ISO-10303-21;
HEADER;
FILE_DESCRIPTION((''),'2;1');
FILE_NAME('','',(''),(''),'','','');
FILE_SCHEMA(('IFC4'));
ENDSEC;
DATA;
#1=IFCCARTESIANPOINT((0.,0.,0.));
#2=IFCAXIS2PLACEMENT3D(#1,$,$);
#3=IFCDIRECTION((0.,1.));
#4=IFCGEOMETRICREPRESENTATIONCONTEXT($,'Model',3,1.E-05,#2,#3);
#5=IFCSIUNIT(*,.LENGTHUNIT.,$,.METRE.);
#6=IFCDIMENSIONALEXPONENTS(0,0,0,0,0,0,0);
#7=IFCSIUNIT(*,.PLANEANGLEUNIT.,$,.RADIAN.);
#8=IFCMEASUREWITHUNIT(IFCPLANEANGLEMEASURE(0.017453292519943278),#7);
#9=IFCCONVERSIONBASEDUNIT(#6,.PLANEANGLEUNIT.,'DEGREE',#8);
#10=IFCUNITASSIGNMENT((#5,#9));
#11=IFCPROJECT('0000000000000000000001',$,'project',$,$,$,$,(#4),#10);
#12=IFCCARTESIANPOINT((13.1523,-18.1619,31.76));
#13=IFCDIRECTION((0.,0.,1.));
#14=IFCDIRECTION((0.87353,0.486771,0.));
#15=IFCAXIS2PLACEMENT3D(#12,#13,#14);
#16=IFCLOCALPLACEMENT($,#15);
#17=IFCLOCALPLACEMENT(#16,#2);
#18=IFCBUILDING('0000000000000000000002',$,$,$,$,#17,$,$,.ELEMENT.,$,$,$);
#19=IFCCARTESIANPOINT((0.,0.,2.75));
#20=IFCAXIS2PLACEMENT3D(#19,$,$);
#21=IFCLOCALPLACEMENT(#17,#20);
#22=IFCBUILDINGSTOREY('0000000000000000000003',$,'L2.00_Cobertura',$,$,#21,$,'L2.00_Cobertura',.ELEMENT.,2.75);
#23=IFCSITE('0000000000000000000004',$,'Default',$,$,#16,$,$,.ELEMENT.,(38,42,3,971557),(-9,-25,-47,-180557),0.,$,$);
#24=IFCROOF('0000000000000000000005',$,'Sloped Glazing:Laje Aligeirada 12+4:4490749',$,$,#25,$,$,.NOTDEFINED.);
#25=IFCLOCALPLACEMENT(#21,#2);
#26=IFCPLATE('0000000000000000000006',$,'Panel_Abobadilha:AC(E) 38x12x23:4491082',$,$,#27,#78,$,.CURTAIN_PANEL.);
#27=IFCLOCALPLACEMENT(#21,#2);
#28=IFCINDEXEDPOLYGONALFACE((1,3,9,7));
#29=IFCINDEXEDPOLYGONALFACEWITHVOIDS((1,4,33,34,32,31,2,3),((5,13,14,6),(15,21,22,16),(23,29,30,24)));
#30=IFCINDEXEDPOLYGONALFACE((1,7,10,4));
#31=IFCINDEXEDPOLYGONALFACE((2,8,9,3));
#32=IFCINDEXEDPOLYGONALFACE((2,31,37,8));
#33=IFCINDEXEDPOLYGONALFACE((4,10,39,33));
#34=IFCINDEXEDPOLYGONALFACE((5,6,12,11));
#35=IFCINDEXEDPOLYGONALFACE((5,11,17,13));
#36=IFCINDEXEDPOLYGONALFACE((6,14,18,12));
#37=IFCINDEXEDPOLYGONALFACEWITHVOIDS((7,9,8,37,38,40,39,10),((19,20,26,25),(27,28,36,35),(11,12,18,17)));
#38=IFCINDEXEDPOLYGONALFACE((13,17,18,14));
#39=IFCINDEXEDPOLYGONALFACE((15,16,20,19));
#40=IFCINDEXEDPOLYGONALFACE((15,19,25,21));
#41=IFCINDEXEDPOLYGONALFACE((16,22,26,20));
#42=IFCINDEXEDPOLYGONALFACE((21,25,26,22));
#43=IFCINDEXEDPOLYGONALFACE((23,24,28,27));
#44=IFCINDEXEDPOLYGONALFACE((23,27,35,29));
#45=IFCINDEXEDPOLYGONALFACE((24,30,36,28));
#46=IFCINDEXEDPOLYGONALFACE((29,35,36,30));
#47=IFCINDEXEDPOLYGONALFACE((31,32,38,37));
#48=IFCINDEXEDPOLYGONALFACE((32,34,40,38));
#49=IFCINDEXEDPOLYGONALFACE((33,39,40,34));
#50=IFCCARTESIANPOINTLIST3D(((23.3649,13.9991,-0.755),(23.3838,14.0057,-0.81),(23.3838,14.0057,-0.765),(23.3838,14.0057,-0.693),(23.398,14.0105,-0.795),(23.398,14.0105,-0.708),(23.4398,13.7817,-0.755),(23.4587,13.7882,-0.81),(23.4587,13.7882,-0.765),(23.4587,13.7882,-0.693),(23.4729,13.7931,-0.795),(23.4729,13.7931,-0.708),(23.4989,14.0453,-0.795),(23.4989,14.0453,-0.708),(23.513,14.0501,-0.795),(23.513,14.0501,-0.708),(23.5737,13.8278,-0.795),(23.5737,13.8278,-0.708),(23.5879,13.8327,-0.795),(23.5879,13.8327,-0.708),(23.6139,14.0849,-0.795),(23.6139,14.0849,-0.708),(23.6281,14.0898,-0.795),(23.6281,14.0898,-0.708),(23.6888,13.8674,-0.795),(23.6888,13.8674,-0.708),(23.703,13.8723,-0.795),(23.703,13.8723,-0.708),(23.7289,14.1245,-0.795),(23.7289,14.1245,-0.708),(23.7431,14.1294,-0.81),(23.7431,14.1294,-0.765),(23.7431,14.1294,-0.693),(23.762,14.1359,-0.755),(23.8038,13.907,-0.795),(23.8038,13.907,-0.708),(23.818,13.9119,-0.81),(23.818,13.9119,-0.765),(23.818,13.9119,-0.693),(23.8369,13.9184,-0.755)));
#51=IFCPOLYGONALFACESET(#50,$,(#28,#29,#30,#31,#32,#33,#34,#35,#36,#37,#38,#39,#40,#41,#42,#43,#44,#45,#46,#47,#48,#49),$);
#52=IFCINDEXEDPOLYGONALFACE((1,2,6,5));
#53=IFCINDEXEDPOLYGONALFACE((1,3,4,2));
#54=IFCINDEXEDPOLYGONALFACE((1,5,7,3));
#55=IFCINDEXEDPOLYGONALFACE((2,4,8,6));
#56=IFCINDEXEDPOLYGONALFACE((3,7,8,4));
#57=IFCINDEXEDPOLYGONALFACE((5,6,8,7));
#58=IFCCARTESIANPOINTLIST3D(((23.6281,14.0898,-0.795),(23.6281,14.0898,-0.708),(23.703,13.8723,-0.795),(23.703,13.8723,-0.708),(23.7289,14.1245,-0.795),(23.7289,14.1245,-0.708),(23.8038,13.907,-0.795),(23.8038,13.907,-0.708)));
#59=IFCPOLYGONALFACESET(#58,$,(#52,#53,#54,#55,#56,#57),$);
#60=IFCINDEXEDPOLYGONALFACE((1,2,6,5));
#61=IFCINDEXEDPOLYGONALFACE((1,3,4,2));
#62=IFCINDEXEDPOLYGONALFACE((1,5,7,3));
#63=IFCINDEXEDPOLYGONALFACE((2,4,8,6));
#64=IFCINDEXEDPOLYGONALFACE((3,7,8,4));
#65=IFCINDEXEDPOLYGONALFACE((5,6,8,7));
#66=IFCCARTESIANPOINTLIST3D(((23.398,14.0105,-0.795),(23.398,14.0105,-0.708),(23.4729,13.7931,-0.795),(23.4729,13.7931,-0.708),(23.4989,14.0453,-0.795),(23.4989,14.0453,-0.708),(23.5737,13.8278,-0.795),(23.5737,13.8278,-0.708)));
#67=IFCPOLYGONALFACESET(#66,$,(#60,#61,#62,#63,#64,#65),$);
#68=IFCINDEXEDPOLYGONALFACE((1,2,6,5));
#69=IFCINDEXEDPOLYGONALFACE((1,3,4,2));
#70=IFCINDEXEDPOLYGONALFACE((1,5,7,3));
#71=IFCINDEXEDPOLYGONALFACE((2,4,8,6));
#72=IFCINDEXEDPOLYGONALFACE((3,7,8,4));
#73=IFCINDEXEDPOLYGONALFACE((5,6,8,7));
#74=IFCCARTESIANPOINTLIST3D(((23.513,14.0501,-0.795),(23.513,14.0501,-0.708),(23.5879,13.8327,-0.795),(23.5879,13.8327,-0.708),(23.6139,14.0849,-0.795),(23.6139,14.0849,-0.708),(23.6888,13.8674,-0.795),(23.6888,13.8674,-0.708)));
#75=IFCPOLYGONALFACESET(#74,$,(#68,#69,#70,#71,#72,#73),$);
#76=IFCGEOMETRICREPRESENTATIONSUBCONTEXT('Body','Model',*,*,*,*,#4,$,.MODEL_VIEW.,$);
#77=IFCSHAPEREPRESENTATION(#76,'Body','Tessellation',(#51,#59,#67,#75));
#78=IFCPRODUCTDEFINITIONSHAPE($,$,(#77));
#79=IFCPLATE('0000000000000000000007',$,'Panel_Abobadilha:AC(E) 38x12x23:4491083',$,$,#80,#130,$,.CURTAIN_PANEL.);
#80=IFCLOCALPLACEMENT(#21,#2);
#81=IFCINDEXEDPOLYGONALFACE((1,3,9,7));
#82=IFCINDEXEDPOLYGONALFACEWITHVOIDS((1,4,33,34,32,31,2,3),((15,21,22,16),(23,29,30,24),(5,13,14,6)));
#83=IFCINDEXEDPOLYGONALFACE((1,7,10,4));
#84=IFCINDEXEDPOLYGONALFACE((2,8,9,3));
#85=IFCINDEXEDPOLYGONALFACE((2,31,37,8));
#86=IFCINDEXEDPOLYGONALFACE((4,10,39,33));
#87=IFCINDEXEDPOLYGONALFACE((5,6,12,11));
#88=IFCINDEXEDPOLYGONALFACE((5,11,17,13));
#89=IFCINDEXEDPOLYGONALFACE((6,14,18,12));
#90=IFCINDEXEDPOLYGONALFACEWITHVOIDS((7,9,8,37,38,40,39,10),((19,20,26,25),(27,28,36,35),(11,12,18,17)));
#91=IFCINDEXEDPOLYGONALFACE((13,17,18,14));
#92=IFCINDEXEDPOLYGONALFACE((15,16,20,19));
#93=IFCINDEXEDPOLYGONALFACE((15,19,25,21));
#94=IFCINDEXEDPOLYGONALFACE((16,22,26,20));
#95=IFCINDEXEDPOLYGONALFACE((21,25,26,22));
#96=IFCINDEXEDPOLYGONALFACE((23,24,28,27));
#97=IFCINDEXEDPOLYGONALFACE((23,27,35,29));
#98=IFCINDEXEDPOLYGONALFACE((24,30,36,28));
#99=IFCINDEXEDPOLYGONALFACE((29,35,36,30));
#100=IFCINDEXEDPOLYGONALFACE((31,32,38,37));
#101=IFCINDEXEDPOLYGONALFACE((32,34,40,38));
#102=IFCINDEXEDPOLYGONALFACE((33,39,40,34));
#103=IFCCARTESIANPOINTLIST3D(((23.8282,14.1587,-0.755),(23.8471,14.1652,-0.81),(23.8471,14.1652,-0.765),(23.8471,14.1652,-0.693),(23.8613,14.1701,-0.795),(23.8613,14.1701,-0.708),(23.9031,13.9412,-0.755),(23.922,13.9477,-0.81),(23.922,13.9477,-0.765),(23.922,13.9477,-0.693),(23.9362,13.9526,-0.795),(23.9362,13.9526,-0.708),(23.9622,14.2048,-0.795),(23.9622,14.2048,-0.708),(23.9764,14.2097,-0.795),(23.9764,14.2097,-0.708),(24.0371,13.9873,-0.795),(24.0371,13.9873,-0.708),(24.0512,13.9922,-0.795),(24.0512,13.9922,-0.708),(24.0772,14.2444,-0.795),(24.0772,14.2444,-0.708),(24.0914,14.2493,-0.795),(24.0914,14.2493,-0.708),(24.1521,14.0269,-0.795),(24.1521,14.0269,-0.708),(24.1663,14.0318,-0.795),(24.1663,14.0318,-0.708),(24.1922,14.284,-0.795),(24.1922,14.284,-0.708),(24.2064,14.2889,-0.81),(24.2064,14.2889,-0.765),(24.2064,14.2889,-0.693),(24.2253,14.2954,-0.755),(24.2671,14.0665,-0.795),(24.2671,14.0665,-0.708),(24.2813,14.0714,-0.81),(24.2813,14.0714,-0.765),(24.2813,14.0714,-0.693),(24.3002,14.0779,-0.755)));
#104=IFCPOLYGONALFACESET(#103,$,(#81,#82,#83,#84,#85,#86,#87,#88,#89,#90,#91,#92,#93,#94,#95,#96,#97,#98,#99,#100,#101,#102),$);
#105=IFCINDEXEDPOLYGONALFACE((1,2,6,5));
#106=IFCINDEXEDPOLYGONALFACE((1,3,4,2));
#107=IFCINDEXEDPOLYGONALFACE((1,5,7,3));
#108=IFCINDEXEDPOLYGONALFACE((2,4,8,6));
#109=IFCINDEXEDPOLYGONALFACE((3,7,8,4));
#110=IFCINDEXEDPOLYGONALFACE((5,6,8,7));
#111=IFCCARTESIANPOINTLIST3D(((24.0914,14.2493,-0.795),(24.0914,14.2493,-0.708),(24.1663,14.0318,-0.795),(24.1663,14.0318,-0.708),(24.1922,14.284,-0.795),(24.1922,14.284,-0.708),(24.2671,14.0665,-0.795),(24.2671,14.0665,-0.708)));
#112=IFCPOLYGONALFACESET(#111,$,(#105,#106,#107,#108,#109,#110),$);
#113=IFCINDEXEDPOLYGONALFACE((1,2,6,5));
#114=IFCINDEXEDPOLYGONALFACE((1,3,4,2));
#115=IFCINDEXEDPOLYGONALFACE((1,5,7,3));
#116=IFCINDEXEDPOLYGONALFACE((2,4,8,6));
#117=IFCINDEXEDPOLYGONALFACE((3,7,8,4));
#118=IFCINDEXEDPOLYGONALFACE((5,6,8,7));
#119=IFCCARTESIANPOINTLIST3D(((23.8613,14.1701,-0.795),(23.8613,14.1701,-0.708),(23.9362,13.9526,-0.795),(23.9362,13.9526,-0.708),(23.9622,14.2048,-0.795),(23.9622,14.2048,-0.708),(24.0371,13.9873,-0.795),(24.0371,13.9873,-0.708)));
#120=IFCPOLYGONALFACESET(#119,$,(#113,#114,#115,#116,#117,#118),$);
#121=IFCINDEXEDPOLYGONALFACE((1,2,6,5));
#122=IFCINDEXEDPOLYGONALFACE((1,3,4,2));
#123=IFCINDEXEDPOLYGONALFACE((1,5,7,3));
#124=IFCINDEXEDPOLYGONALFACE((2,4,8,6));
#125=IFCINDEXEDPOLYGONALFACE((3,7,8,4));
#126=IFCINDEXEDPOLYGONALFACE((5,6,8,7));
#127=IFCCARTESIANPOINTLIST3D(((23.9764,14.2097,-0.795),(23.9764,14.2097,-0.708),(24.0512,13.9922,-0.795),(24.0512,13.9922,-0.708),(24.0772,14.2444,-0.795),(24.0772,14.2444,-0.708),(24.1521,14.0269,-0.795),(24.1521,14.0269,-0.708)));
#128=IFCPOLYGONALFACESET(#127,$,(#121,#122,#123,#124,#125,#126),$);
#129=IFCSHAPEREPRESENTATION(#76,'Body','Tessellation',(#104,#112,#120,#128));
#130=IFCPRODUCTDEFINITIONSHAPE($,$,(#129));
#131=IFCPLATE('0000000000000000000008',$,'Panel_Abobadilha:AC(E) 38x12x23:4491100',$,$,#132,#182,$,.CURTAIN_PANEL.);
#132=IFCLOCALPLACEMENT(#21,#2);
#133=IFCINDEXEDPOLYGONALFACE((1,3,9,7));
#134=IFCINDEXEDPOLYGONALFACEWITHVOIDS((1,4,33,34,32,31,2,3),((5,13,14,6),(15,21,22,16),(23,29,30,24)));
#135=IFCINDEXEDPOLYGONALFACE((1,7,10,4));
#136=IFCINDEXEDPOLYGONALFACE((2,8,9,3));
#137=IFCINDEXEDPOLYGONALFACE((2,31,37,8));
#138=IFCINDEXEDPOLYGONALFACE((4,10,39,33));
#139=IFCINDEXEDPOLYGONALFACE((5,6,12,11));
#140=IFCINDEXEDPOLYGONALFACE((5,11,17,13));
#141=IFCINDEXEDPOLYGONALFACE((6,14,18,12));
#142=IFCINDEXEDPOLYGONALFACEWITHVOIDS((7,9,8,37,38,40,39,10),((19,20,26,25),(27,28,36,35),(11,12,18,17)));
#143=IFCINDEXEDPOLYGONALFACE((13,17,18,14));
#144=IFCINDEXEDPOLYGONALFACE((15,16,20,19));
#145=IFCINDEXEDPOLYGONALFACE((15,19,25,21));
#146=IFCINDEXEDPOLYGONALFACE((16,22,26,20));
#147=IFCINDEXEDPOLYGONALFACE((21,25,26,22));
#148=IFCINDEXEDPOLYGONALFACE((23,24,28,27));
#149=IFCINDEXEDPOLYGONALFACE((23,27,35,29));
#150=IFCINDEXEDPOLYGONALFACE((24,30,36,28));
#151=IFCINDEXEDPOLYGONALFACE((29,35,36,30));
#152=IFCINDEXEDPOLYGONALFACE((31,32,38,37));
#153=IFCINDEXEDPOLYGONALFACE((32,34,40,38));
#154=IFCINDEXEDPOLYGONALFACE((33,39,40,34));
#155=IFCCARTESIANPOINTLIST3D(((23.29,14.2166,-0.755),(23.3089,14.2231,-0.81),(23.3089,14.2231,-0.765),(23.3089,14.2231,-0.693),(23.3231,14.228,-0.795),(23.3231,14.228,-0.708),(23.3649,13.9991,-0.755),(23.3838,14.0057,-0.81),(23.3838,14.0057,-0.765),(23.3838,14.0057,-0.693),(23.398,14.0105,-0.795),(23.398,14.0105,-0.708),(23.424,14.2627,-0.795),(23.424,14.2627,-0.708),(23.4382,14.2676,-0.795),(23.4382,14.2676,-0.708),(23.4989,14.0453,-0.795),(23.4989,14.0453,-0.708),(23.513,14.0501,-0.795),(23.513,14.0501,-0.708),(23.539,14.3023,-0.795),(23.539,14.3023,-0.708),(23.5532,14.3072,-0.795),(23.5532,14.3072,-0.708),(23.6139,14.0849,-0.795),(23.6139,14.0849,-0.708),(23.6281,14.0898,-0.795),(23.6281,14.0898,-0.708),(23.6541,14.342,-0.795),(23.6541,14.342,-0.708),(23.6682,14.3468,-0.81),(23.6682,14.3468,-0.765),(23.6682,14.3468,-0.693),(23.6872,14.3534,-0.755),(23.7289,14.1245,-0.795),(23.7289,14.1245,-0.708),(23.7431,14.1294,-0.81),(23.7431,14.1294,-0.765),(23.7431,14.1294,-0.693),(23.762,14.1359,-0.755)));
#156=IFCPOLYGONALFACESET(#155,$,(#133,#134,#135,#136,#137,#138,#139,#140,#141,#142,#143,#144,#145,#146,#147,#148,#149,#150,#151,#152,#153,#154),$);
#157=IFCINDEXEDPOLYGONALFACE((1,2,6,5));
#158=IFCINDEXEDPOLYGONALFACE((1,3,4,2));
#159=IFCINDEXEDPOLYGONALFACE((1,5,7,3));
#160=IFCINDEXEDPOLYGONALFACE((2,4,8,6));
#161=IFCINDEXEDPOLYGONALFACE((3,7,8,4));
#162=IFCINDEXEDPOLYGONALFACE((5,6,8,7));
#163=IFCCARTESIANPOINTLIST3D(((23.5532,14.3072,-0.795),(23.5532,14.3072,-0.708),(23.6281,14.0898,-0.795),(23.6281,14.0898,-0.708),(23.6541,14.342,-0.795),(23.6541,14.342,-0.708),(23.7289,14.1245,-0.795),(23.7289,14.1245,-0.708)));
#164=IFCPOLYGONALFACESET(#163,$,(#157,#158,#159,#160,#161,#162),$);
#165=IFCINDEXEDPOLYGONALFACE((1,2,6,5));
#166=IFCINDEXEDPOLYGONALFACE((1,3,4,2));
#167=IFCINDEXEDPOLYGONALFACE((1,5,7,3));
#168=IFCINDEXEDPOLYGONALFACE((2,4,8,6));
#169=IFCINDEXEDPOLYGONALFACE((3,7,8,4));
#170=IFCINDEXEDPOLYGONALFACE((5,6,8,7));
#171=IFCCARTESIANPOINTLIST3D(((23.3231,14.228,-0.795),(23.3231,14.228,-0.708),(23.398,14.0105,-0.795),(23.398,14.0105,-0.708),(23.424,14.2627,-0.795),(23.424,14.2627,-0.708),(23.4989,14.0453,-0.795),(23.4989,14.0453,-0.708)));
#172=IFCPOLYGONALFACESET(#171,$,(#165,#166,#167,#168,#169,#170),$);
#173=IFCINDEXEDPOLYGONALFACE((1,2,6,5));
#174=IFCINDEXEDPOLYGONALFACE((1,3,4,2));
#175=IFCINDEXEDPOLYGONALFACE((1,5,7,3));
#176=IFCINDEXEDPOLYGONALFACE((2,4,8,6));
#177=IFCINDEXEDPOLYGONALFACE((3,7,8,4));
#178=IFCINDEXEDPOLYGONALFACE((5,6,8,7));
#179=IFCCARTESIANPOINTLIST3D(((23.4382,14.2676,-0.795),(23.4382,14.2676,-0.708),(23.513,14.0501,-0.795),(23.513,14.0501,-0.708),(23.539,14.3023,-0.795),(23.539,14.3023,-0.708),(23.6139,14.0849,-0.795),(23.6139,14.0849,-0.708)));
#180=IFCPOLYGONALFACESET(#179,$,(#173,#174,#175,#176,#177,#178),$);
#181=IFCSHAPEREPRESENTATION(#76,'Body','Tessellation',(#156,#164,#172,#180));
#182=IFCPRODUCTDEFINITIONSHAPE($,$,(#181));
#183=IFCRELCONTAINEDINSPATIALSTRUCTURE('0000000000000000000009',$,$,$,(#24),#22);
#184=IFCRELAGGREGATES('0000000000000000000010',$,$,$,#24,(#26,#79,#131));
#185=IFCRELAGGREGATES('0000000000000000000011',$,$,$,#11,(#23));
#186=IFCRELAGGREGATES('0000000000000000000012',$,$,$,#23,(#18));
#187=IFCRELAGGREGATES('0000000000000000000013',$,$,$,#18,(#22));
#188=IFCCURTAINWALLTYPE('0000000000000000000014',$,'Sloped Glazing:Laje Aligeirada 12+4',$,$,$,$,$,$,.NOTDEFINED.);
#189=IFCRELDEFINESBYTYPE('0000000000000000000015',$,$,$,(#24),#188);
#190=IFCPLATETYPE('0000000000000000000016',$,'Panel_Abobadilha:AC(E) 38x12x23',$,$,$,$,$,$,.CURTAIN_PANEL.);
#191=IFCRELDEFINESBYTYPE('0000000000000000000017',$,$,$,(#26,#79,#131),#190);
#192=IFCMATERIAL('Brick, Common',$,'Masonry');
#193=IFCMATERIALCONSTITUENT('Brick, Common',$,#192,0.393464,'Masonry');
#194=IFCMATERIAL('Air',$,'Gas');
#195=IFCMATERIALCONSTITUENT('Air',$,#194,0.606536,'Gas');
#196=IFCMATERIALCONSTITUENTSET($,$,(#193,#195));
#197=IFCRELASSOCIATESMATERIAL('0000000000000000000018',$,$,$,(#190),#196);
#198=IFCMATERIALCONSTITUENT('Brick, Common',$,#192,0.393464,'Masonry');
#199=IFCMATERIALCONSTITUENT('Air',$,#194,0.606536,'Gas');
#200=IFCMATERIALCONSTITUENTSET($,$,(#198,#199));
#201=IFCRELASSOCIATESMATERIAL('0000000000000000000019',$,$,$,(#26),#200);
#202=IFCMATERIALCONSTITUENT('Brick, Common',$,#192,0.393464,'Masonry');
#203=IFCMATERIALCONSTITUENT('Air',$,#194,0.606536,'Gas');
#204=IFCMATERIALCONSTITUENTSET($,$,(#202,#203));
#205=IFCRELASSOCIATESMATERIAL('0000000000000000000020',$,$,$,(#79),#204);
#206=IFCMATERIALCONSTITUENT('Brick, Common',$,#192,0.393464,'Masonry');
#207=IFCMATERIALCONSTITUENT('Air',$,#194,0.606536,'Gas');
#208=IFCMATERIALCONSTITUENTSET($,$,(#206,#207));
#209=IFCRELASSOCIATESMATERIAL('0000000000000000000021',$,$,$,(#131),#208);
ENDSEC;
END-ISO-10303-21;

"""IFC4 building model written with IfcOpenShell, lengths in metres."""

from ifc_helpers import new_model, entity, si_unit, converted_unit, direction, frame, origin, place, context, subcontext, project, spatial, indexed_curve, outline, extrude, source, transform, mapped, material, constituent, constituent_set, type_object, type_shapes, element, aggregate, save


model = new_model("IFC4")

# Units and contexts
model_context = context("Model", 3, precision=1e-05, world=origin(), true_north=direction((0.0, 1.0)))
body_context = subcontext(model_context, "Body", "Model", "MODEL_VIEW")
ifc_project = project(units=[si_unit("LENGTHUNIT", "METRE"), converted_unit("PLANEANGLEUNIT", "DEGREE", entity("IfcPlaneAngleMeasure", 0.017453292519943278), si_unit("PLANEANGLEUNIT", "RADIAN"), dimensions=[0, 0, 0, 0, 0, 0, 0])], contexts=[model_context])

# Site, building, storey
site_placement = place(None, frame((13.1523, -18.1619, 31.76), z_axis=(0.0, 0.0, 1.0), x_axis=(0.87353, 0.486771, 0.0)))
site = spatial("IfcSite", under=ifc_project, at=site_placement, Name="Default", CompositionType="ELEMENT", RefLatitude=(38, 42, 3, 971557), RefLongitude=(-9, -25, -47, -180557), RefElevation=0.0)
building_placement = place(site_placement, origin())
building = spatial("IfcBuilding", under=site, at=building_placement, CompositionType="ELEMENT")
storey_placement = place(building_placement, frame((0.0, 0.0, 2.75)))
storey = spatial("IfcBuildingStorey", under=building, at=storey_placement, Name="L2.00_Cobertura", LongName="L2.00_Cobertura", CompositionType="ELEMENT", Elevation=2.75)

# Roof, plates
curtain_wall_type = type_object("IfcCurtainWallType", Name="Sloped Glazing:Laje Aligeirada 12+4", PredefinedType="NOTDEFINED")
roof_placement = place(storey_placement, frame((0.0, 0.0, -2.75)))
roof = element("IfcRoof", 1, at=roof_placement, inside=storey, type_object=curtain_wall_type, Name="Sloped Glazing:Laje Aligeirada 12+4:4490749", PredefinedType="NOTDEFINED")
ifc_material_1 = material(Name="Brick, Common", Category="Masonry")
ifc_constituent_1 = constituent(ifc_material_1, Name="Brick, Common", Category="Masonry", fraction=0.393464)
ifc_material_2 = material(Name="Air", Category="Gas")
ifc_constituent_2 = constituent(ifc_material_2, Name="Air", Category="Gas", fraction=0.606536)
ifc_constituent_set_1 = constituent_set(constituents=[ifc_constituent_1, ifc_constituent_2])
ifc_constituent_3 = constituent(ifc_material_1, Name="Brick, Common", Category="Masonry", fraction=0.393464)
ifc_constituent_4 = constituent(ifc_material_2, Name="Air", Category="Gas", fraction=0.606536)
ifc_constituent_set_2 = constituent_set(constituents=[ifc_constituent_3, ifc_constituent_4])
plate_type = type_object("IfcPlateType", Name="Panel_Abobadilha:AC(E) 38x12x23", PredefinedType="CURTAIN_PANEL", material=ifc_constituent_set_2)
shared_shape_1 = source(origin(), body_context, "Body", "SweptSolid", [
    extrude(outline(indexed_curve([(-0.19, -0.0543), (0.19, -0.0543), (0.19, -0.0093), (0.21, 0.0007), (0.19, 0.0628), (-0.19, 0.0628), (-0.21, 0.0007), (-0.19, -0.0093), (-0.19, -0.0543)], self_intersect=False), holes=[indexed_curve([(-0.0683, 0.0477), (-0.0683, -0.0393), (-0.175, -0.0393), (-0.175, 0.0477), (-0.0683, 0.0477)], self_intersect=False), indexed_curve([(0.0533, 0.0477), (0.0533, -0.0393), (-0.0533, -0.0393), (-0.0533, 0.0477), (0.0533, 0.0477)], self_intersect=False), indexed_curve([(0.175, 0.0477), (0.175, -0.0393), (0.0683, -0.0393), (0.0683, 0.0477), (0.175, 0.0477)], self_intersect=False)]), frame((0.0, 0.0543, 0.0)), (0.0, 0.0, 1.0), 0.23),
    extrude(outline(indexed_curve([(-0.0533, -0.0435), (0.0533, -0.0435), (0.0533, 0.0435), (-0.0533, 0.0435), (-0.0533, -0.0435)], self_intersect=False)), frame((0.1217, 0.0585, 0.0), z_axis=(0.0, 0.0, 1.0), x_axis=(-1.0, 0.0, 0.0)), (0.0, 0.0, 1.0), 0.23),
    extrude(outline(indexed_curve([(-0.0533, -0.0435), (0.0533, -0.0435), (0.0533, 0.0435), (-0.0533, 0.0435), (-0.0533, -0.0435)], self_intersect=False)), frame((-0.1217, 0.0585, 0.0), z_axis=(0.0, 0.0, 1.0), x_axis=(-1.0, 0.0, 0.0)), (0.0, 0.0, 1.0), 0.23),
    extrude(outline(indexed_curve([(-0.0533, -0.0435), (0.0533, -0.0435), (0.0533, 0.0435), (-0.0533, 0.0435), (-0.0533, -0.0435)], self_intersect=False)), frame((0.0, 0.0585, 0.0), z_axis=(0.0, 0.0, 1.0), x_axis=(-1.0, 0.0, 0.0)), (0.0, 0.0, 1.0), 0.23),
])
type_shapes(plate_type, [shared_shape_1])
plate_1_placement = place(roof_placement, frame((23.5635, 14.0675, 1.94), z_axis=(0.325568, -0.945519, 0.0), x_axis=(0.945519, 0.325568, 0.0)))
plate_1 = element("IfcPlate", 2, at=plate_1_placement, type_object=plate_type, material=ifc_constituent_set_1, Name="Panel_Abobadilha:AC(E) 38x12x23:4491082", PredefinedType="CURTAIN_PANEL", context=body_context, shape_type="MappedRepresentation", body=[
    mapped(shared_shape_1, transform((0.0, 0.0, 0.0), scale=1.0)),
])
ifc_constituent_5 = constituent(ifc_material_1, Name="Brick, Common", Category="Masonry", fraction=0.393464)
ifc_constituent_6 = constituent(ifc_material_2, Name="Air", Category="Gas", fraction=0.606536)
ifc_constituent_set_3 = constituent_set(constituents=[ifc_constituent_5, ifc_constituent_6])
plate_2_placement = place(roof_placement, frame((24.0268, 14.227, 1.94), z_axis=(0.325568, -0.945519, 0.0), x_axis=(0.945519, 0.325568, 0.0)))
plate_2 = element("IfcPlate", 3, at=plate_2_placement, type_object=plate_type, material=ifc_constituent_set_3, Name="Panel_Abobadilha:AC(E) 38x12x23:4491083", PredefinedType="CURTAIN_PANEL", context=body_context, shape_type="MappedRepresentation", body=[
    mapped(shared_shape_1, transform((0.0, 0.0, 0.0), scale=1.0)),
])
ifc_constituent_7 = constituent(ifc_material_1, Name="Brick, Common", Category="Masonry", fraction=0.393464)
ifc_constituent_8 = constituent(ifc_material_2, Name="Air", Category="Gas", fraction=0.606536)
ifc_constituent_set_4 = constituent_set(constituents=[ifc_constituent_7, ifc_constituent_8])
plate_3_placement = place(roof_placement, frame((23.4886, 14.285, 1.94), z_axis=(0.325568, -0.945519, 0.0), x_axis=(0.945519, 0.325568, 0.0)))
plate_3 = element("IfcPlate", 4, at=plate_3_placement, type_object=plate_type, material=ifc_constituent_set_4, Name="Panel_Abobadilha:AC(E) 38x12x23:4491100", PredefinedType="CURTAIN_PANEL", context=body_context, shape_type="MappedRepresentation", body=[
    mapped(shared_shape_1, transform((0.0, 0.0, 0.0), scale=1.0)),
])
aggregate(roof, [plate_1, plate_2, plate_3])

save(model, "model.ifc")
